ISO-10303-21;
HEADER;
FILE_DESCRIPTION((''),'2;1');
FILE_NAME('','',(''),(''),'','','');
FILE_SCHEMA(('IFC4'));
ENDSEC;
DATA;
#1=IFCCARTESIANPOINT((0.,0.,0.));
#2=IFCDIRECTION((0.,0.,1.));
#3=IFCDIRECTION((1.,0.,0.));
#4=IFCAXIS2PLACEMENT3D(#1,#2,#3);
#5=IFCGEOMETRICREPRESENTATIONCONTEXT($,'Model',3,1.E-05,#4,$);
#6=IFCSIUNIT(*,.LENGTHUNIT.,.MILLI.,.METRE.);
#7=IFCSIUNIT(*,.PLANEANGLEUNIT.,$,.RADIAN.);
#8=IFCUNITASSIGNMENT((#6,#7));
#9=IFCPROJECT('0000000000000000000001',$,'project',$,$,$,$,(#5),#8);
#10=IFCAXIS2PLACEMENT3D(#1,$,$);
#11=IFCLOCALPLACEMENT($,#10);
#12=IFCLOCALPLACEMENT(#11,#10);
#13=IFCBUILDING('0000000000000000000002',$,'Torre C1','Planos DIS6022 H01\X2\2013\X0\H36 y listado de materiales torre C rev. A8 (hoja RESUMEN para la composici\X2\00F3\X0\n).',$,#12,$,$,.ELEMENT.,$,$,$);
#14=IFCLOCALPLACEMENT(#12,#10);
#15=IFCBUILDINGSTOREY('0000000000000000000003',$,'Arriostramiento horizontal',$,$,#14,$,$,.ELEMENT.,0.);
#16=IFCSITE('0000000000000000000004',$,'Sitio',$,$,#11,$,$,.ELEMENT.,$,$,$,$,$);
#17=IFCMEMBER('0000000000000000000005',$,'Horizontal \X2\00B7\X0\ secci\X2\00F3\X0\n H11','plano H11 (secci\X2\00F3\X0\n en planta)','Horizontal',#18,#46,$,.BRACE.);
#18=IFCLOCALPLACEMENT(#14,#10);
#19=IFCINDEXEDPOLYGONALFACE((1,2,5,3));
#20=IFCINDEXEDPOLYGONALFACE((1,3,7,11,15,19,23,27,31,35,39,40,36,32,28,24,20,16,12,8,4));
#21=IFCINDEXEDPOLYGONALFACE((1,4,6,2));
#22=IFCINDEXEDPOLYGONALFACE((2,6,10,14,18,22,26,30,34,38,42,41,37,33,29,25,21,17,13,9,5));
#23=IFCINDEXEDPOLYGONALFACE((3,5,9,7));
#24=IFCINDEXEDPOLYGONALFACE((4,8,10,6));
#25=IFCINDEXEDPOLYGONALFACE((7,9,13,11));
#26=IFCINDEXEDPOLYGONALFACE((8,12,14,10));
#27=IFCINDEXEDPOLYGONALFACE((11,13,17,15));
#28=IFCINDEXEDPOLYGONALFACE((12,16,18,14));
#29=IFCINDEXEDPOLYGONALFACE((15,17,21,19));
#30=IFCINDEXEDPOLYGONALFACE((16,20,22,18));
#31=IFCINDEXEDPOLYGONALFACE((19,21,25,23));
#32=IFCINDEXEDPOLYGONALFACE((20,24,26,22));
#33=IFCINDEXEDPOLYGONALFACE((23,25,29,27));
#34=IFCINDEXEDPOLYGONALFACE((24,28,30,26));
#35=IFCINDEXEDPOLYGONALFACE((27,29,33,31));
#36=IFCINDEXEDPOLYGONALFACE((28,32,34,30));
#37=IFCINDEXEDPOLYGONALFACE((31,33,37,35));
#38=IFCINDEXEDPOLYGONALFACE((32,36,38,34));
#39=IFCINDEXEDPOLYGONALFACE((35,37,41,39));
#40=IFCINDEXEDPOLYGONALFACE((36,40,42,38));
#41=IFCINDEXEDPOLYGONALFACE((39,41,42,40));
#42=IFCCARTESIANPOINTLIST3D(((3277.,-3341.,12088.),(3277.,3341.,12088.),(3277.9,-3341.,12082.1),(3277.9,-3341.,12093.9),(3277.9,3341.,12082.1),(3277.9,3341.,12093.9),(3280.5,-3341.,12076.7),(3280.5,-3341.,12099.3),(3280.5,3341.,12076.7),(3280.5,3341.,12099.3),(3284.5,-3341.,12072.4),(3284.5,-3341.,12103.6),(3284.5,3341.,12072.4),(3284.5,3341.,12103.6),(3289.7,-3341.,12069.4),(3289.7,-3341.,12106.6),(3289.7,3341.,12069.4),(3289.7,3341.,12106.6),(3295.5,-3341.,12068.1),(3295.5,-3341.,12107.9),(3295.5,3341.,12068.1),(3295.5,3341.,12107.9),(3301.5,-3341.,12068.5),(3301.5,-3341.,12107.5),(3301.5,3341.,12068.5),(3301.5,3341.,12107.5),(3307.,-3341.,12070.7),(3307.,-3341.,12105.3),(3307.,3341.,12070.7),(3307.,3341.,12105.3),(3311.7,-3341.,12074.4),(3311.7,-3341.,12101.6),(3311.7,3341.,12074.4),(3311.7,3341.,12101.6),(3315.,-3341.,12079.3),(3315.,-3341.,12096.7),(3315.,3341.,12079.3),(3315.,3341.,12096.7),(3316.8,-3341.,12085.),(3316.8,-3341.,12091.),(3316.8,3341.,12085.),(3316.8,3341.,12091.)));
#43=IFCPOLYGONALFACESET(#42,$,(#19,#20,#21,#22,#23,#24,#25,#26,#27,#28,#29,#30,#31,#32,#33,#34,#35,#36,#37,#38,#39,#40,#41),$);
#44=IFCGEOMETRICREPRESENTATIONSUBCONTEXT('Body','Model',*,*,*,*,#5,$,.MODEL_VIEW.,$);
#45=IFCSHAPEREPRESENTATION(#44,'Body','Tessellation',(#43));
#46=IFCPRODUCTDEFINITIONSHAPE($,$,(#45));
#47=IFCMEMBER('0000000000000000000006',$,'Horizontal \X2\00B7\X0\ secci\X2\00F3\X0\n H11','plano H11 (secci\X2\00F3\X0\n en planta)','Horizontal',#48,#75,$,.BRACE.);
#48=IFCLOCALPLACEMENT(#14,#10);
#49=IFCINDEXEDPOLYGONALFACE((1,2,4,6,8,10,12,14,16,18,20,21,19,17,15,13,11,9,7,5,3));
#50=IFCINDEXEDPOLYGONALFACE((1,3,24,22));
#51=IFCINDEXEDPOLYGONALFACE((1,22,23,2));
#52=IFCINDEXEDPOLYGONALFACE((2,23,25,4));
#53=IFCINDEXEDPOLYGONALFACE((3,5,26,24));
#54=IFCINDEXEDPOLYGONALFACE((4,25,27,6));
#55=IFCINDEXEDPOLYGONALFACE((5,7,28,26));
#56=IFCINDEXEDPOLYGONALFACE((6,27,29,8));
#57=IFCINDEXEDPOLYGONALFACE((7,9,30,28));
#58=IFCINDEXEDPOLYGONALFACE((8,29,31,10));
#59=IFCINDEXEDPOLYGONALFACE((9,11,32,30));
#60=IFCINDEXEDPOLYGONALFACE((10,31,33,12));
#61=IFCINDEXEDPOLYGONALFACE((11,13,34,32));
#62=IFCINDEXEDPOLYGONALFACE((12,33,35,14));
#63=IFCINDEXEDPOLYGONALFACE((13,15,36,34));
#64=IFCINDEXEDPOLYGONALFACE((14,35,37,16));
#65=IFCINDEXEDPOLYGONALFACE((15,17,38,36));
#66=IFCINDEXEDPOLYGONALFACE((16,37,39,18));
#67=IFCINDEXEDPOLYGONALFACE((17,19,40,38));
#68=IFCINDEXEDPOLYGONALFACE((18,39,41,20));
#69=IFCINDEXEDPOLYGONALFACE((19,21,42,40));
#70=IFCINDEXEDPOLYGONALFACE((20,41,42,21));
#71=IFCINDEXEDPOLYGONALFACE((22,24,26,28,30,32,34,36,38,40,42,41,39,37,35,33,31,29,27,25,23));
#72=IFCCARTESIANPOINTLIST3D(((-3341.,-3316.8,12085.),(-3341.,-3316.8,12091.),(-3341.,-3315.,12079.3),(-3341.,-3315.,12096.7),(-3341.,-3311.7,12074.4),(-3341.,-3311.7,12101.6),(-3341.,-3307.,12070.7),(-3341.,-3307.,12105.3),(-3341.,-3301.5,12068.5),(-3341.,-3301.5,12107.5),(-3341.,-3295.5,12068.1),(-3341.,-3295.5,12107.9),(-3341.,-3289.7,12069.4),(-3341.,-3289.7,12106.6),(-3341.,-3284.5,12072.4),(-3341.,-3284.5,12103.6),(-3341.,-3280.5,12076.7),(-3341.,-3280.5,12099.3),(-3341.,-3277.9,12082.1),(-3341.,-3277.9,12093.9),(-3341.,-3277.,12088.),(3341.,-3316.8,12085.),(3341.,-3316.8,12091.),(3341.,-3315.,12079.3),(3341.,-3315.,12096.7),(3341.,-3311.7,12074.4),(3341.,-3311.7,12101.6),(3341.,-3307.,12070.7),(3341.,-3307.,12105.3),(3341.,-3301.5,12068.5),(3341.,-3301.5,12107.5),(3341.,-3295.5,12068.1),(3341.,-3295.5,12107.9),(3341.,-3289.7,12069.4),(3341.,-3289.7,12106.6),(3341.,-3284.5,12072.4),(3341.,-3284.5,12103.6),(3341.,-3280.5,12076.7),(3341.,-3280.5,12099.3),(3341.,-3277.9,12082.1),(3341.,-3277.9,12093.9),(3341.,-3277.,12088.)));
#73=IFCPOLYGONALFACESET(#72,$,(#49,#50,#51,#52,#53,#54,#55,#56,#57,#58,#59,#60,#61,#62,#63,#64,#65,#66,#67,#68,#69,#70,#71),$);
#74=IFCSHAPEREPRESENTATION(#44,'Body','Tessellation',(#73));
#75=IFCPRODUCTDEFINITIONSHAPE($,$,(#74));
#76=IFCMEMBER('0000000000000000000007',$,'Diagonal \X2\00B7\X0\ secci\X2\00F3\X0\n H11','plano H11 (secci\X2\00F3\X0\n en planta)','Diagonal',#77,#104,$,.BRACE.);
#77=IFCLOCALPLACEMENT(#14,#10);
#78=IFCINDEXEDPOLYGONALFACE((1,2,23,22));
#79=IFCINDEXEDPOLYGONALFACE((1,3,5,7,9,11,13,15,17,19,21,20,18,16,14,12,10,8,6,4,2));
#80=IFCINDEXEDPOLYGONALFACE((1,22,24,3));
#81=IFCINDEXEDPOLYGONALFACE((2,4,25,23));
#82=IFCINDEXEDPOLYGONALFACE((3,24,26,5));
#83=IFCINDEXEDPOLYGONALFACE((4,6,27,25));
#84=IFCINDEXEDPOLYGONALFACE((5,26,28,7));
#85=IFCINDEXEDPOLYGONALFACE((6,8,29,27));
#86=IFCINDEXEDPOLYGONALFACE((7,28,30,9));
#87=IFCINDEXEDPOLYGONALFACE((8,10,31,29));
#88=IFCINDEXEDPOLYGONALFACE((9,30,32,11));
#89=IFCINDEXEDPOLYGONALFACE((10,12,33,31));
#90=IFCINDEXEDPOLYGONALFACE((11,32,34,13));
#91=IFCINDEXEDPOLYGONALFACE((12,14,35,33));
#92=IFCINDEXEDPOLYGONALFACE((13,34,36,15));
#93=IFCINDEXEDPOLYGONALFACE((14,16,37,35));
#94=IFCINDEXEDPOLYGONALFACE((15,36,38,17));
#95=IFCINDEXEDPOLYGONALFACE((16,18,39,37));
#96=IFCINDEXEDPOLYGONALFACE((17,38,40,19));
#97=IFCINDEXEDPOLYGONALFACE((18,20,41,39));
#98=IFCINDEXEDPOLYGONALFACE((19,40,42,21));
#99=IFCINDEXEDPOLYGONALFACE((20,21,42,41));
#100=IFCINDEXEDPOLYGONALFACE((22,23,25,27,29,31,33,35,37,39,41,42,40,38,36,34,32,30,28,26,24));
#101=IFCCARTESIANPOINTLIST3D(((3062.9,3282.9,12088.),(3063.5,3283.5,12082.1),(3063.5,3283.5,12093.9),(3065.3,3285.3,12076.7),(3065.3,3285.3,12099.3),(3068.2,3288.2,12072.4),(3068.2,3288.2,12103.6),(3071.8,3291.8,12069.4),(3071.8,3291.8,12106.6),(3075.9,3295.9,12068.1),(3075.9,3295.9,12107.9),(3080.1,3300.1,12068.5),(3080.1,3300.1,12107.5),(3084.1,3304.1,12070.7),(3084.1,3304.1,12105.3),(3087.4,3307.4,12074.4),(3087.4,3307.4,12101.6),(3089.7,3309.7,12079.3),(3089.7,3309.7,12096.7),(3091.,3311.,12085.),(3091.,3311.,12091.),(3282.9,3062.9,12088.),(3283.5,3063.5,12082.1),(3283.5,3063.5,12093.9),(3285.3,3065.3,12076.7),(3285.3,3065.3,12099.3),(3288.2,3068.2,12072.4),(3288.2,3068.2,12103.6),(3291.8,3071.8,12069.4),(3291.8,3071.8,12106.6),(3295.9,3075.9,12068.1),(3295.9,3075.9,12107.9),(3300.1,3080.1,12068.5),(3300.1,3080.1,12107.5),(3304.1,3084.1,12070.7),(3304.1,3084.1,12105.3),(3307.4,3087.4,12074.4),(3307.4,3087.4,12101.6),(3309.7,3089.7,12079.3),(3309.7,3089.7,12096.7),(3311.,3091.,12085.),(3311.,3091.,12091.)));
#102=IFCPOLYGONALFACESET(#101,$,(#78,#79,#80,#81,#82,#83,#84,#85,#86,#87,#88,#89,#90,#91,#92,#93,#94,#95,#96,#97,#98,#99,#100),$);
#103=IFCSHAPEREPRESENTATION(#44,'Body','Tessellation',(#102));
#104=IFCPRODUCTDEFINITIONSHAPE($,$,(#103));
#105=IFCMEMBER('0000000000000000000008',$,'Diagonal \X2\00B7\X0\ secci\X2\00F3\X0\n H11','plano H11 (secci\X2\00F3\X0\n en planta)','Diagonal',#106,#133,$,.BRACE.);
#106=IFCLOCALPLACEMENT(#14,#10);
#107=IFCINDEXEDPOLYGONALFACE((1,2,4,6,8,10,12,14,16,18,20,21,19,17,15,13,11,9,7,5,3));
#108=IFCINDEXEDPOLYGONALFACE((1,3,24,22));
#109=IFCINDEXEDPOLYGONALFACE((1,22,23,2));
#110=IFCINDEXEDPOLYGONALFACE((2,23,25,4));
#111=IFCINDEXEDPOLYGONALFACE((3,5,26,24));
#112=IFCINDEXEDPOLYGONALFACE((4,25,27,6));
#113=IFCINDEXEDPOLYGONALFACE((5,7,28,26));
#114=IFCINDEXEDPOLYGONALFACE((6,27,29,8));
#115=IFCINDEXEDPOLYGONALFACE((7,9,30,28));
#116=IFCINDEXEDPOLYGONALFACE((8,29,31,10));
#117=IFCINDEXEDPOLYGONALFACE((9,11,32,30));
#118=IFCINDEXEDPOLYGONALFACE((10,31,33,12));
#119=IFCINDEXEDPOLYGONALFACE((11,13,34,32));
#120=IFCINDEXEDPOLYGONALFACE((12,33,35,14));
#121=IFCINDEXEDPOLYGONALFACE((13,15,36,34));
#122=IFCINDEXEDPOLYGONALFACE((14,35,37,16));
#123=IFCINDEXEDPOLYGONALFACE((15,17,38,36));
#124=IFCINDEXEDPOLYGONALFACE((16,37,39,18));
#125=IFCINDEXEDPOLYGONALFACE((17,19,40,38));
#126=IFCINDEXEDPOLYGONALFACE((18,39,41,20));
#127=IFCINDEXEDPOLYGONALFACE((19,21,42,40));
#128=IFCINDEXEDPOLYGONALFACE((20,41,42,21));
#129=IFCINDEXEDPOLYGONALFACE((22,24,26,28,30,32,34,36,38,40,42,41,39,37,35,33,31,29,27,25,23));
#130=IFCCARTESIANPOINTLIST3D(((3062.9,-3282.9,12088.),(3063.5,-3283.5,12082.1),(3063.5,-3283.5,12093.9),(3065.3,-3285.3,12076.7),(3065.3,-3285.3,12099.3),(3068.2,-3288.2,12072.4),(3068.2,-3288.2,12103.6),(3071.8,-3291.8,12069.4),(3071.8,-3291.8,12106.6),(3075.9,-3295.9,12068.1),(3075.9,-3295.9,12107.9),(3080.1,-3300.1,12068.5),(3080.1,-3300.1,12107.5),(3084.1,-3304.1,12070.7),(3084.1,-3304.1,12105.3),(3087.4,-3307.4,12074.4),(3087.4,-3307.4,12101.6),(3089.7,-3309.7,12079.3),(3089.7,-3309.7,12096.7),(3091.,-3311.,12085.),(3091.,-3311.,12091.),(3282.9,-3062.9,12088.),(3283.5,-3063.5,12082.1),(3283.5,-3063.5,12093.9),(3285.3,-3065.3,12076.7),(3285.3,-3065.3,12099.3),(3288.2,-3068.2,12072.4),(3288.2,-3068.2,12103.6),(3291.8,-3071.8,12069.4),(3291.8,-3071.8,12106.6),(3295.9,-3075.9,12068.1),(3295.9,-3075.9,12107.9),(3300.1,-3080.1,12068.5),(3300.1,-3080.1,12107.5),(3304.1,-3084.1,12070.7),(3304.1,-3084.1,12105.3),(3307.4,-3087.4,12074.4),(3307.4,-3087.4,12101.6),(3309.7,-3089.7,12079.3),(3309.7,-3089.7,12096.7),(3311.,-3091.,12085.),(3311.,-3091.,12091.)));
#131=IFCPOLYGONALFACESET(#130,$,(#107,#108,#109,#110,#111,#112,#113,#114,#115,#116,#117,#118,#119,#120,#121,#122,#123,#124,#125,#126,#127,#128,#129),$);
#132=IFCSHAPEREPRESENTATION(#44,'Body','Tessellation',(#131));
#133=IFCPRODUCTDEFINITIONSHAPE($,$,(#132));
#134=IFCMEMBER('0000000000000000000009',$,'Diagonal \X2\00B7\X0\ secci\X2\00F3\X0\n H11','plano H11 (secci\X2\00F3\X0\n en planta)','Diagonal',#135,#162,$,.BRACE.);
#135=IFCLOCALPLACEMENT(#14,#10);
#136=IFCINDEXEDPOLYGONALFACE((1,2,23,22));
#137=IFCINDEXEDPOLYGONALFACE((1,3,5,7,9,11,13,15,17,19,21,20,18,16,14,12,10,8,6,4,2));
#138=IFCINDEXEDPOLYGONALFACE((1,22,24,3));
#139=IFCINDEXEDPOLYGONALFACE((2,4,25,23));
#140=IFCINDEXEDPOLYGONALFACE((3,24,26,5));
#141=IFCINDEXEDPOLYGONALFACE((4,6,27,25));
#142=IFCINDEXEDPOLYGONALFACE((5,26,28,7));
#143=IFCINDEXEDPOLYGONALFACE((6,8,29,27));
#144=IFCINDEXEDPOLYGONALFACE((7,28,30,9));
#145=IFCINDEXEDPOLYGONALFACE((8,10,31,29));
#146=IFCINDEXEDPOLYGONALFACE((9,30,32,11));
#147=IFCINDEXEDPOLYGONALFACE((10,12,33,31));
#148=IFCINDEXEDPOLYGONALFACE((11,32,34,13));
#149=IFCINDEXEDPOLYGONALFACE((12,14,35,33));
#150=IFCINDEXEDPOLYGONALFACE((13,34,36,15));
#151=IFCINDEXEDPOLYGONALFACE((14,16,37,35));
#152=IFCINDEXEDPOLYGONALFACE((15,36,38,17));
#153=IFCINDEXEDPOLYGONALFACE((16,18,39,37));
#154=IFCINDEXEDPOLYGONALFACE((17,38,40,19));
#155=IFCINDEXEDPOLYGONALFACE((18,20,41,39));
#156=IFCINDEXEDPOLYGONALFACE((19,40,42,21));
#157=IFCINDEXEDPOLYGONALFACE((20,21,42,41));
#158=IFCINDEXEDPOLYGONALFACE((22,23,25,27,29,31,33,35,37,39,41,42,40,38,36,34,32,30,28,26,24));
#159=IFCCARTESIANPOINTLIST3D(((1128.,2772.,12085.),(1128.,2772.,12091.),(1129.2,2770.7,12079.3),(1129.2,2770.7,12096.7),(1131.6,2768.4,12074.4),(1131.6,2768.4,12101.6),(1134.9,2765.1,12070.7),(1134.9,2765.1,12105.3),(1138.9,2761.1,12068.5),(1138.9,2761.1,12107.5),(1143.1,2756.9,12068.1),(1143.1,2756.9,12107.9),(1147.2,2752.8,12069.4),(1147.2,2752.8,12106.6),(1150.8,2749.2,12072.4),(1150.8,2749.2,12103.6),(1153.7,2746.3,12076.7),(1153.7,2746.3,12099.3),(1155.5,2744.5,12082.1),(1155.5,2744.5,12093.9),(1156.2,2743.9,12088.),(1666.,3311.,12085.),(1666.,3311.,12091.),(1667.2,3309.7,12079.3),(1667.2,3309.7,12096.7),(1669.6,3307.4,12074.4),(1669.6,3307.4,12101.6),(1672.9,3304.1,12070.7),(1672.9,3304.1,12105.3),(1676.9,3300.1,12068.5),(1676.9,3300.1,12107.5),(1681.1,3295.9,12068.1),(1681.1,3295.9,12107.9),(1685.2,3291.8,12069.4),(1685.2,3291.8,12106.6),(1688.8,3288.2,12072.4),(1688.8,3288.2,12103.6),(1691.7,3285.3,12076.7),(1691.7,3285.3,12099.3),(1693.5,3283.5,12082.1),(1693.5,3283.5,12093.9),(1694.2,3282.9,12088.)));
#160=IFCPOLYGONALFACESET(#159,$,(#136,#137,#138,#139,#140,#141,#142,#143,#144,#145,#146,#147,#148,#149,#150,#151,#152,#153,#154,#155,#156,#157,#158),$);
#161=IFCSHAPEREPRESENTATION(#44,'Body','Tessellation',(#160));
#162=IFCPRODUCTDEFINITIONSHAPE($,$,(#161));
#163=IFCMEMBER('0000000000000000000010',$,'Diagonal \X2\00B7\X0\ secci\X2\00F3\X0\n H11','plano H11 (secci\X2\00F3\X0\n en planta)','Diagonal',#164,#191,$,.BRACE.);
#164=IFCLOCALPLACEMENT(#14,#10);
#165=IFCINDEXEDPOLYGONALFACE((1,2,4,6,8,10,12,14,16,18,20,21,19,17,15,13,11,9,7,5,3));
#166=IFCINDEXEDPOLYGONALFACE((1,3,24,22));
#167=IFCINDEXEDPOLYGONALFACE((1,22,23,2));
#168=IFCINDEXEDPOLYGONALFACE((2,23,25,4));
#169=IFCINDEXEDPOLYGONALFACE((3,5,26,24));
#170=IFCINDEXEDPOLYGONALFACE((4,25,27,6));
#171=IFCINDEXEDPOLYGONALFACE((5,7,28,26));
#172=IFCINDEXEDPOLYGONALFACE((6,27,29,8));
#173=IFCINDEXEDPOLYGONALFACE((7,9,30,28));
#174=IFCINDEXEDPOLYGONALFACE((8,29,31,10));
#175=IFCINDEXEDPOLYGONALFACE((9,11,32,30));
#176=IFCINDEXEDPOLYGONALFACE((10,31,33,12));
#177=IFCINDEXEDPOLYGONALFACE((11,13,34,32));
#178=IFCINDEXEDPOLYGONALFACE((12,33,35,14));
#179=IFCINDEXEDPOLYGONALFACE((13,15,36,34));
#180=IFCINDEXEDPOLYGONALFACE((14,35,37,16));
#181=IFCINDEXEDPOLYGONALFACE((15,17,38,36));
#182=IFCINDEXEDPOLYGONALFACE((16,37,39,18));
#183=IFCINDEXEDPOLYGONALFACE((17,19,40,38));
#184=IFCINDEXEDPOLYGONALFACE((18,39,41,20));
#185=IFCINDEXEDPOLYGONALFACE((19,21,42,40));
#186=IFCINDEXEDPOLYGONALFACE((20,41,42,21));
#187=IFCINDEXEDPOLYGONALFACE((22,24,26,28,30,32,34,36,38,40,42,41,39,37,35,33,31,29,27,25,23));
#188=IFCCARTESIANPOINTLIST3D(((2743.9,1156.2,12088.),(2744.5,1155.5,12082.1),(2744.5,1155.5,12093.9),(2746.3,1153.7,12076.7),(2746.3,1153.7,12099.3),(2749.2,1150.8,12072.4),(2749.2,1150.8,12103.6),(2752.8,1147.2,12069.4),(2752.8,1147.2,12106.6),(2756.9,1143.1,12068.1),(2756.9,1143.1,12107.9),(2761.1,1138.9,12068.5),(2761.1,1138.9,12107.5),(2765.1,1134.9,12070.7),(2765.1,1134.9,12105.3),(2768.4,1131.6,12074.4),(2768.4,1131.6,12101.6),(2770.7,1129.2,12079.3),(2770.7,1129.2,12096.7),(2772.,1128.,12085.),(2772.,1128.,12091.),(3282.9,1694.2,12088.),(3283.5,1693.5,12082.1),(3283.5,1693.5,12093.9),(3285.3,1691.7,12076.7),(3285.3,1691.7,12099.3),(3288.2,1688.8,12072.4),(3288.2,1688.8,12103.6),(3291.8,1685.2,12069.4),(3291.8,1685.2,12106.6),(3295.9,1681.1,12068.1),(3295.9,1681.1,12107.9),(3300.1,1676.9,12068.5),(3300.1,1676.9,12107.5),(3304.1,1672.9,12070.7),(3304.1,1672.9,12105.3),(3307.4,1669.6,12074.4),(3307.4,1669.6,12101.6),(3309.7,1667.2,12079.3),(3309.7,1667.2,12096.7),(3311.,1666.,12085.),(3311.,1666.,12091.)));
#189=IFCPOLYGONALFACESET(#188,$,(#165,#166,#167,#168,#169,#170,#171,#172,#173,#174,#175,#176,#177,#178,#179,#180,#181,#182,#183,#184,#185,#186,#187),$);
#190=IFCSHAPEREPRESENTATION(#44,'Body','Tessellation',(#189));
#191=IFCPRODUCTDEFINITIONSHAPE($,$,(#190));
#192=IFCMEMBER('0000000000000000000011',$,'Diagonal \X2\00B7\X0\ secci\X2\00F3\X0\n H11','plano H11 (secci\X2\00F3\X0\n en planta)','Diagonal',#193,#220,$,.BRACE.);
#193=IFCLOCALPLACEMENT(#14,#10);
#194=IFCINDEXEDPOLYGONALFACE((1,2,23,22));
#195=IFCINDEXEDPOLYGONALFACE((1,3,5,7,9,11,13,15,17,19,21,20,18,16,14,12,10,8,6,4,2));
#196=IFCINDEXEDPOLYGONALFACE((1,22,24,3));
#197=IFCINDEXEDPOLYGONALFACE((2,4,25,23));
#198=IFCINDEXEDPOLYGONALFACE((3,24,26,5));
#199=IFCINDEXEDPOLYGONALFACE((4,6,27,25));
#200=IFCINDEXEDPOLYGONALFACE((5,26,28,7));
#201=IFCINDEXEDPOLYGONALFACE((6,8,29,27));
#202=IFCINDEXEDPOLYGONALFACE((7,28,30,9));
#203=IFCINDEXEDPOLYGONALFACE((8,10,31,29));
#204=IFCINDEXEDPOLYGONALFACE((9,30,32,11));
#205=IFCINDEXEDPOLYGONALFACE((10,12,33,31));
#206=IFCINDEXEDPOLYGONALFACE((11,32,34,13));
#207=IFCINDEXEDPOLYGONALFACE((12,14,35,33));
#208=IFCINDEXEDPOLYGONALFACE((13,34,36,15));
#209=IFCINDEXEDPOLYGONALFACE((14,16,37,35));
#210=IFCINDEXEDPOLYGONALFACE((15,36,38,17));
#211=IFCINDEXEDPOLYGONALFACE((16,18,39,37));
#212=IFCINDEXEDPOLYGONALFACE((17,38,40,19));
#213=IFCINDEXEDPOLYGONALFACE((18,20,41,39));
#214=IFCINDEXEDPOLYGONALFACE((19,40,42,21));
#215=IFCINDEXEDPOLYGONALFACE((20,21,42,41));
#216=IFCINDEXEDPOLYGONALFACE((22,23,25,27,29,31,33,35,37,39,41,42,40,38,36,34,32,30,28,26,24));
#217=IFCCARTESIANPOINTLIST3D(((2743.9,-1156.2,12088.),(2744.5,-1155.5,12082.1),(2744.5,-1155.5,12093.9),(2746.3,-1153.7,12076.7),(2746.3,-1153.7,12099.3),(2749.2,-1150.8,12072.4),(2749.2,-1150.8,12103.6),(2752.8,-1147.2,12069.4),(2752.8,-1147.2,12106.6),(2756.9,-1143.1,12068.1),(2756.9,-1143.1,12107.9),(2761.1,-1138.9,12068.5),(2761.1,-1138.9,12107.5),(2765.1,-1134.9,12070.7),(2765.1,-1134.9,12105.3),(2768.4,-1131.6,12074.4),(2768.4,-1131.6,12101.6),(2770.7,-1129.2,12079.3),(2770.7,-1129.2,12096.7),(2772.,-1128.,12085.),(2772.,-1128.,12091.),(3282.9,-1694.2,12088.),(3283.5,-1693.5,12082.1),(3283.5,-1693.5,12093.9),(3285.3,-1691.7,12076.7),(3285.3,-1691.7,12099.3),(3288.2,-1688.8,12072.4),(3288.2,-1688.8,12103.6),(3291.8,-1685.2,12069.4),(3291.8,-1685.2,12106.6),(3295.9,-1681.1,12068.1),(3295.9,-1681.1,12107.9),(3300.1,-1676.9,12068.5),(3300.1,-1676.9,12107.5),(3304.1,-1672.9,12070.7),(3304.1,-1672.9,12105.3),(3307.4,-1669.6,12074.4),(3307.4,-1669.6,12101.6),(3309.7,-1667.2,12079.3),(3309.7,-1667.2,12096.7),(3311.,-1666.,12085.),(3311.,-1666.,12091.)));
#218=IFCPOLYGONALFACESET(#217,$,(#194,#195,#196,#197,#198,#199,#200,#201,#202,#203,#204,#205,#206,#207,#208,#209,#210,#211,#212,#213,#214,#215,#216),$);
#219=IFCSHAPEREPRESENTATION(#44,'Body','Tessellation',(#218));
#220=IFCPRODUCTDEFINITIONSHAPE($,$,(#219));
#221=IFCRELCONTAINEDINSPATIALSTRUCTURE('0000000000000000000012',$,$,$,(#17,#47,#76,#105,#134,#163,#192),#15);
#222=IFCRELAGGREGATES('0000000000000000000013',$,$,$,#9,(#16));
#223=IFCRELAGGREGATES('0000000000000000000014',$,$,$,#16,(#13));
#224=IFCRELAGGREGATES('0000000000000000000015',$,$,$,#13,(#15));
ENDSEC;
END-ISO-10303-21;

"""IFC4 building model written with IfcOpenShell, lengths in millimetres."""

from ifc_helpers import new_model, si_unit, frame, origin, origin_with_axes, place, context, subcontext, project, spatial, circle, extrude, element, save


model = new_model("IFC4")

# Units and contexts
model_context = context("Model", 3, precision=1e-05, world=origin_with_axes())
body_context = subcontext(model_context, "Body", "Model", "MODEL_VIEW")
ifc_project = project(units=[si_unit("LENGTHUNIT", "METRE", prefix="MILLI"), si_unit("PLANEANGLEUNIT", "RADIAN")], contexts=[model_context])

# Site, building, storey
site_placement = place(None, origin())
site = spatial("IfcSite", under=ifc_project, at=site_placement, Name="Sitio", CompositionType="ELEMENT")
building_placement = place(site_placement, origin())
building = spatial("IfcBuilding", under=site, at=building_placement, Name="Torre C1", Description="Planos DIS6022 H01–H36 y listado de materiales torre C rev. A8 (hoja RESUMEN para la composición).", CompositionType="ELEMENT")
storey_placement = place(building_placement, origin())
storey = spatial("IfcBuildingStorey", under=building, at=storey_placement, Name="Arriostramiento horizontal", CompositionType="ELEMENT", Elevation=0.0)

# Members
for number, where, z_axis, x_axis, name in (
    (1, (3297.0, 3341.0, 12088.0), (0.0, -1.0, 0.0), (-1.0, 0.0, 0.0), "Horizontal · sección H11"),
    (2, (3341.0, -3297.0, 12088.0), (-1.0, 0.0, 0.0), (0.0, 1.0, 0.0), "Horizontal · sección H11"),
):
    element("IfcMember", number, at=place(storey_placement, frame(where, z_axis=z_axis, x_axis=x_axis)), inside=storey, Name=name, Description="plano H11 (sección en planta)", ObjectType="Horizontal", PredefinedType="BRACE", context=body_context, shape_type="SweptSolid", body=[
        extrude(circle(Radius=20.0), None, (0.0, 0.0, 1.0), 6682.0),
    ])
for number, where, z_axis, x_axis, name in (
    (3, (3297.0, 3077.0, 12088.0), (-0.707107, 0.707107, 0.0), (-0.707107, -0.707107, 0.0), "Diagonal · sección H11"),
    (4, (3077.0, -3297.0, 12088.0), (0.707107, 0.707107, 0.0), (-0.707107, 0.707107, 0.0), "Diagonal · sección H11"),
):
    element("IfcMember", number, at=place(storey_placement, frame(where, z_axis=z_axis, x_axis=x_axis)), inside=storey, Name=name, Description="plano H11 (sección en planta)", ObjectType="Diagonal", PredefinedType="BRACE", context=body_context, shape_type="SweptSolid", body=[
        extrude(circle(Radius=20.0), None, (0.0, 0.0, 1.0), 311.1),
    ])
for number, where, z_axis, x_axis, name in (
    (5, (1680.0, 3297.0, 12088.0), (-0.70645, -0.707763, 0.0), (0.707763, -0.70645, 0.0), "Diagonal · sección H11"),
    (6, (3297.0, 1680.0, 12088.0), (-0.707763, -0.70645, 0.0), (-0.70645, 0.707763, 0.0), "Diagonal · sección H11"),
    (7, (3297.0, -1680.0, 12088.0), (-0.707763, 0.70645, 0.0), (-0.70645, -0.707763, 0.0), "Diagonal · sección H11"),
):
    element("IfcMember", number, at=place(storey_placement, frame(where, z_axis=z_axis, x_axis=x_axis)), inside=storey, Name=name, Description="plano H11 (sección en planta)", ObjectType="Diagonal", PredefinedType="BRACE", context=body_context, shape_type="SweptSolid", body=[
        extrude(circle(Radius=20.0), None, (0.0, 0.0, 1.0), 761.6),
    ])

save(model, "model.ifc")
